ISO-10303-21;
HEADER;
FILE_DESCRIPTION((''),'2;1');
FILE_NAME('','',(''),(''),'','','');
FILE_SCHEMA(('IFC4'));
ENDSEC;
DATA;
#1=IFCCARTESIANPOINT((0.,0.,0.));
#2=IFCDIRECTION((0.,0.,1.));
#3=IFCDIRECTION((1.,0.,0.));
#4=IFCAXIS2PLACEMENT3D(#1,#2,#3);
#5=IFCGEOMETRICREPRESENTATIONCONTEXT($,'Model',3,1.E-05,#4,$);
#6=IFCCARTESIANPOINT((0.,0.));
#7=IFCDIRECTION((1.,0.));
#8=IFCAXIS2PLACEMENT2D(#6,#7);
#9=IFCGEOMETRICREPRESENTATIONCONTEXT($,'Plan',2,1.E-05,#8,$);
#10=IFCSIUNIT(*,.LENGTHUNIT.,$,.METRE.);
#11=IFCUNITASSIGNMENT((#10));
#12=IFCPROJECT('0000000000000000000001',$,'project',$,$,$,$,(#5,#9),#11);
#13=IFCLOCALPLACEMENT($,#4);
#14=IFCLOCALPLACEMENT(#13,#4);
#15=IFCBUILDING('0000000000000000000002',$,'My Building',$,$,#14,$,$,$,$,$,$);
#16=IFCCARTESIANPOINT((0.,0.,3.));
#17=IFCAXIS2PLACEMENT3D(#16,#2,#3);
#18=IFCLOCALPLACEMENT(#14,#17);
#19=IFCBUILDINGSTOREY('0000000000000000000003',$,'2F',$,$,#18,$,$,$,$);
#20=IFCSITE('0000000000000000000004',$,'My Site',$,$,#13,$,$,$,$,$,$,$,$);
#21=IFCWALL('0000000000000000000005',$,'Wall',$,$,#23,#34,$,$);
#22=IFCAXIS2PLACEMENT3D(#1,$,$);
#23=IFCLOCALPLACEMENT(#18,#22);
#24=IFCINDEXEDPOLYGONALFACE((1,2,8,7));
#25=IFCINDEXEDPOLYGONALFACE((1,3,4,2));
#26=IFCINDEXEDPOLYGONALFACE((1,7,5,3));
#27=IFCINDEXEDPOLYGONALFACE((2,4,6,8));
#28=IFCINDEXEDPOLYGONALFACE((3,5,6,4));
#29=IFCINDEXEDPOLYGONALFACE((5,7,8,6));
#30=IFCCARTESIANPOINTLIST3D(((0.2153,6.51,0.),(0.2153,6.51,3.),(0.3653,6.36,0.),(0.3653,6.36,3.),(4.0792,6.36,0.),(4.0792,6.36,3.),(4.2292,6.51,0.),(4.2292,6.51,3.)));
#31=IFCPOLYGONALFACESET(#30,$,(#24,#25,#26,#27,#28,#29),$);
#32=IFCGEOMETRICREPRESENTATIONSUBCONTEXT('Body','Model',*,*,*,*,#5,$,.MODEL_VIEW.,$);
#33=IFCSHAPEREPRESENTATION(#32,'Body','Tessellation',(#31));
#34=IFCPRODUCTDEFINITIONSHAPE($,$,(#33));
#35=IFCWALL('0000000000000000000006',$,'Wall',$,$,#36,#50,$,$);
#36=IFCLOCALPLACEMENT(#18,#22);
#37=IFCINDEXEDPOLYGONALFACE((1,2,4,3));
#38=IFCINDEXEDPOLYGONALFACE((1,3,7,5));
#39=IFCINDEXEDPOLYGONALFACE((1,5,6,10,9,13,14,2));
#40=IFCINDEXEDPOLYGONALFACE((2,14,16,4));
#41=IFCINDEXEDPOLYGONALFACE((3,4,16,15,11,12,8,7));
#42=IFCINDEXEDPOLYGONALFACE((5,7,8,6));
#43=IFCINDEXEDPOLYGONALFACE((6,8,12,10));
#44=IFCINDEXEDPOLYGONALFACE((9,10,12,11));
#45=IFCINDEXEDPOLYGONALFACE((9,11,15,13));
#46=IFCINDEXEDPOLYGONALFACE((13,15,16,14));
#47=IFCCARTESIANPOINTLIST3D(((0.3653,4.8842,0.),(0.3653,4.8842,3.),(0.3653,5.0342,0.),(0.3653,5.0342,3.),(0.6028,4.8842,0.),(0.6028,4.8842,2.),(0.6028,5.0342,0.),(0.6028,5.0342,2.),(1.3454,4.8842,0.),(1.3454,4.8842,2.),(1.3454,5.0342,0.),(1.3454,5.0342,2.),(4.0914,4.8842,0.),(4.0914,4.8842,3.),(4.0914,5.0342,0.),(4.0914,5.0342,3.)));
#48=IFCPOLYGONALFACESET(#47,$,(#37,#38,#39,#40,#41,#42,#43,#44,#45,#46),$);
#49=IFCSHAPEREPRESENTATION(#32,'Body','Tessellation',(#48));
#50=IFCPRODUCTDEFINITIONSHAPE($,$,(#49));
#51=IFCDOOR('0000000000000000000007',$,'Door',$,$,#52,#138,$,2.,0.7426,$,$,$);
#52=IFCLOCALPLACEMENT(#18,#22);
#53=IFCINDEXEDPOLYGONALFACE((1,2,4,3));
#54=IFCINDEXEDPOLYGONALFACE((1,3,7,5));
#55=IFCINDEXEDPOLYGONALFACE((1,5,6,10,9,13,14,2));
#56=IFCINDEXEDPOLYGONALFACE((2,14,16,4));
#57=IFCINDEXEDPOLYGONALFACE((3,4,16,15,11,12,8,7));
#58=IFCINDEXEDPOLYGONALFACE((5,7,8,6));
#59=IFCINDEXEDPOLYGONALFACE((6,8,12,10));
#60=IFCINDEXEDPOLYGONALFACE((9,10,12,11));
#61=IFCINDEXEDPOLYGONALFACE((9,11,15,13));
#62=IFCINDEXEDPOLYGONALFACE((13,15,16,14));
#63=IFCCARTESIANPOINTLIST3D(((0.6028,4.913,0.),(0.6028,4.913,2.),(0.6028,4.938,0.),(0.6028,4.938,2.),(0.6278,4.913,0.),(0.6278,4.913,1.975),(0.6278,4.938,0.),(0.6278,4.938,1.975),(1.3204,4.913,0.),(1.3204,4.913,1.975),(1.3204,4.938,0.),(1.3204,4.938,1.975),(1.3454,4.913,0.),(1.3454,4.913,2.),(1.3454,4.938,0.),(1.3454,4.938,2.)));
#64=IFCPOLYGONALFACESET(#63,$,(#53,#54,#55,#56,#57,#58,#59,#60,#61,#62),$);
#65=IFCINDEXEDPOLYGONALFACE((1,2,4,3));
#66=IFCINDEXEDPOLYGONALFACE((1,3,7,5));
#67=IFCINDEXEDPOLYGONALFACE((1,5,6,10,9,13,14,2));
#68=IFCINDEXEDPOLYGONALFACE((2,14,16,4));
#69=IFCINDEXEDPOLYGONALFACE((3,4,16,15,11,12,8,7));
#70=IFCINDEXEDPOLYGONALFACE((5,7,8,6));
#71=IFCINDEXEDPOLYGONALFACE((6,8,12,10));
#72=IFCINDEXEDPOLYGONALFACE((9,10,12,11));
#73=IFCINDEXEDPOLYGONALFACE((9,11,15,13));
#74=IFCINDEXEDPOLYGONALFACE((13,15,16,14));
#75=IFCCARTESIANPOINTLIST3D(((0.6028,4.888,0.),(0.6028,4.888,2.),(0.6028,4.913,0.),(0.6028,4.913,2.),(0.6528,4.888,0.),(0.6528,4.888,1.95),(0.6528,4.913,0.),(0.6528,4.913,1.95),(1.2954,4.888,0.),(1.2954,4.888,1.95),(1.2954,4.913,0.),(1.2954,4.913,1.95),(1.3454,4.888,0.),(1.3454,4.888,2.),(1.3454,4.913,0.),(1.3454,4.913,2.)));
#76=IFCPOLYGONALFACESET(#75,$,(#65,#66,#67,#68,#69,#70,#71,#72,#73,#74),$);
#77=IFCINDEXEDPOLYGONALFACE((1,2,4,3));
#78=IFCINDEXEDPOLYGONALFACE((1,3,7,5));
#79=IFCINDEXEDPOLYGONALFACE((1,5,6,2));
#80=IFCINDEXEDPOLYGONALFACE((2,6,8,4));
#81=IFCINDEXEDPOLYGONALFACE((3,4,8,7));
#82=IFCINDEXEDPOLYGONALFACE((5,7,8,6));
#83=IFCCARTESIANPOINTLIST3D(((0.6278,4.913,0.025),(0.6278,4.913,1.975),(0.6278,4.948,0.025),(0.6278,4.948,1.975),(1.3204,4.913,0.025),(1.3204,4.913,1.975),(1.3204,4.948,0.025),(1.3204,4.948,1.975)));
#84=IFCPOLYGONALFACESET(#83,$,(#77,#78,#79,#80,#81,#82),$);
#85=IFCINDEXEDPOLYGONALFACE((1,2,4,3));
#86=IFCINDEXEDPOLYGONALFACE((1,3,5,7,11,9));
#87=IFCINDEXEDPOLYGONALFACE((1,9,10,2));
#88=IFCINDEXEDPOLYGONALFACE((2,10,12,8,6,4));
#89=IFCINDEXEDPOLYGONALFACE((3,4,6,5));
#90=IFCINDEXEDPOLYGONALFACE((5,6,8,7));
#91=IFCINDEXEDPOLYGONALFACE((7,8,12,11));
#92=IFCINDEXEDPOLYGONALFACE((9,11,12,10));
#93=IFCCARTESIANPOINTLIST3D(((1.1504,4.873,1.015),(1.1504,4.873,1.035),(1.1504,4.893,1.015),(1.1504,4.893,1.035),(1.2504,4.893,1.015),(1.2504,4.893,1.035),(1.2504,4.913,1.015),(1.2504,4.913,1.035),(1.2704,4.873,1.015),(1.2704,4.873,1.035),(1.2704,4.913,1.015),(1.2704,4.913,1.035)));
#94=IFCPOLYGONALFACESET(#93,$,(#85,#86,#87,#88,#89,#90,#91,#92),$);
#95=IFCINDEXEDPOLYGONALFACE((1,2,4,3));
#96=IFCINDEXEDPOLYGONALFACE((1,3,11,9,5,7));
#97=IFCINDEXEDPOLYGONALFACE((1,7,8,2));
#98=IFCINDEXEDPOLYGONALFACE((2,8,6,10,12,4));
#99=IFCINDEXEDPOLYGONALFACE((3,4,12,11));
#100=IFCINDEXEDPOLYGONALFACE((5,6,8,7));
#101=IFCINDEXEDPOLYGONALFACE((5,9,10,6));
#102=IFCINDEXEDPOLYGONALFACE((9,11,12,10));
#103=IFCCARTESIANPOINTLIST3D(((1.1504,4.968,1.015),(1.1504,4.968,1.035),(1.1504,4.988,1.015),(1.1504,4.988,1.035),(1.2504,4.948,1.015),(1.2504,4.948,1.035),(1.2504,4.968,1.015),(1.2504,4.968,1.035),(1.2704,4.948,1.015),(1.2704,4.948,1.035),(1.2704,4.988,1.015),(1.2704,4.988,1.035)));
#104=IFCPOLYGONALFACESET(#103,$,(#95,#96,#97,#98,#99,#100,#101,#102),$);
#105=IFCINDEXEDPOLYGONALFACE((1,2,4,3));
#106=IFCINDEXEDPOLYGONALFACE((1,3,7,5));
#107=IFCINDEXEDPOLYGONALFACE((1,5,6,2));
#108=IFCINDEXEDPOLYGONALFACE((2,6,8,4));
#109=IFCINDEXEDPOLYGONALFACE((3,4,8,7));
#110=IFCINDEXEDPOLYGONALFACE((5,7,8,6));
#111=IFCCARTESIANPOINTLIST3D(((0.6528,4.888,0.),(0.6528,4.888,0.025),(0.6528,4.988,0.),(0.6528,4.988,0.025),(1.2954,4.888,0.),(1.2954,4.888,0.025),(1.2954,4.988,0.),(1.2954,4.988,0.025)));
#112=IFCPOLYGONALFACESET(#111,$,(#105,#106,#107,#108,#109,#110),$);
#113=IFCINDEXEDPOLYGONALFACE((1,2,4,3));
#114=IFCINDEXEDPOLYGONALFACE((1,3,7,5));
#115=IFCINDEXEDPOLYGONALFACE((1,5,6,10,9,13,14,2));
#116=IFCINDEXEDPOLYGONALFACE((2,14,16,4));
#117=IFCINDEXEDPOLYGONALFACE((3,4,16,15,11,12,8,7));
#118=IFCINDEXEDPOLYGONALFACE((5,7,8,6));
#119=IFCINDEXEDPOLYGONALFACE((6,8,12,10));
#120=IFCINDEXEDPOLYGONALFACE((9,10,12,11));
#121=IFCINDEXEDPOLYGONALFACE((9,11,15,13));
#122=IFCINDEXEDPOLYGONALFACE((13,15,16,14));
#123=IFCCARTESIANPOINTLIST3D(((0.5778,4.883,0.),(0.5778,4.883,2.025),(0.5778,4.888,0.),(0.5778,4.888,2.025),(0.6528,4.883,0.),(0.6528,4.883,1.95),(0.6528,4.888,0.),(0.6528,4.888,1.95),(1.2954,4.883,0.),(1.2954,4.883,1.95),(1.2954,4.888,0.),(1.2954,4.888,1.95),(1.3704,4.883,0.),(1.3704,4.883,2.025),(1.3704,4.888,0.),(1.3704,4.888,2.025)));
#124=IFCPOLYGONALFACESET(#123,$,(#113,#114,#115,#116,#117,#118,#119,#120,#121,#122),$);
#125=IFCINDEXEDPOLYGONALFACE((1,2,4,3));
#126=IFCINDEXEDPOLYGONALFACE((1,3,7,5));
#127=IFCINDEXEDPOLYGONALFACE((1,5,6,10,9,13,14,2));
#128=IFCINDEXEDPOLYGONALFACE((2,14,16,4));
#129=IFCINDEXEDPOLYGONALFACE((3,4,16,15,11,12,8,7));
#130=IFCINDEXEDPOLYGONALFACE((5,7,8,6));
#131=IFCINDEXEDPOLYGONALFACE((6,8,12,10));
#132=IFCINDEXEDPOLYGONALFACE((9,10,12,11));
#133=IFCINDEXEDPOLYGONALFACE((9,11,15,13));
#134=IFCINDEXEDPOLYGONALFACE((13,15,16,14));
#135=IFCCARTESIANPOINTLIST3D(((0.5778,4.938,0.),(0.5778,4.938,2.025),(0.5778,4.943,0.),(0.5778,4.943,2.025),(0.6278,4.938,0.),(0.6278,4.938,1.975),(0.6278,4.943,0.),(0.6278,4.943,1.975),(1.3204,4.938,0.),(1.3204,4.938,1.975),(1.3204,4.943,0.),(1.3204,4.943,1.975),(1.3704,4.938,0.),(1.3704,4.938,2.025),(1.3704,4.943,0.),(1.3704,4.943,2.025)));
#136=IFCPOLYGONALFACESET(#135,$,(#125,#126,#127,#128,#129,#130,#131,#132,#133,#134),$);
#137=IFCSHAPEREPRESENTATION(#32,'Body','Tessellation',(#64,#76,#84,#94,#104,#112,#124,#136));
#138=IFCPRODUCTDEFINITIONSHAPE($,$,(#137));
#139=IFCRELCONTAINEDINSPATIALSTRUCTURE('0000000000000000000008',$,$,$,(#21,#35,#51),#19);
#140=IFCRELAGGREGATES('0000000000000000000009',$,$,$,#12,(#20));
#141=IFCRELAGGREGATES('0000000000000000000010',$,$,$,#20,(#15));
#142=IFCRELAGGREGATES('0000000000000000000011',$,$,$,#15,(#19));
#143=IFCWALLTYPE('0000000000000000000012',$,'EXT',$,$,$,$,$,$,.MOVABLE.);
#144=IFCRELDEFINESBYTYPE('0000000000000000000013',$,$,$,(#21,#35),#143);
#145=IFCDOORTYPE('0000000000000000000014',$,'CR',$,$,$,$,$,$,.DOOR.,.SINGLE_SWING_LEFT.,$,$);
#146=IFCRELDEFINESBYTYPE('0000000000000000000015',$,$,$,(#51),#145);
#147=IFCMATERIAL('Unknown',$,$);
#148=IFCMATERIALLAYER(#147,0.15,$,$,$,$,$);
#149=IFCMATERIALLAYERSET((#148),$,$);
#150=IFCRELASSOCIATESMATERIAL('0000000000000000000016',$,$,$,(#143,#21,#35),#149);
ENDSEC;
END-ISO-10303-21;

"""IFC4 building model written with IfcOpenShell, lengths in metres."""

from ifc_helpers import new_model, entity, si_unit, frame, origin_with_axes, origin_2d_with_axis, place, context, subcontext, project, spatial, line, indexed_curve, outline, extrude, shape, source, transform, mapped, material, layer, layer_set, layer_usage, type_object, type_shapes, element, fill, save


model = new_model("IFC4")

# Units and contexts
model_context = context("Model", 3, precision=1e-05, world=origin_with_axes())
plan_context = context("Plan", 2, precision=1e-05, world=origin_2d_with_axis())
body_context_1 = subcontext(model_context, "Body", "Model", "MODEL_VIEW")
body_context_2 = subcontext(plan_context, "Body", "Plan", "PLAN_VIEW")
ifc_project = project(units=[si_unit("LENGTHUNIT", "METRE")], contexts=[model_context, plan_context])

# Site, building, storey
site_placement = place(None, origin_with_axes())
site = spatial("IfcSite", under=ifc_project, at=site_placement, Name="My Site")
building_placement = place(site_placement, origin_with_axes())
building = spatial("IfcBuilding", under=site, at=building_placement, Name="My Building")
storey_placement = place(building_placement, frame((0.0, 0.0, 3.0), z_axis=(0.0, 0.0, 1.0), x_axis=(1.0, 0.0, 0.0)))
storey = spatial("IfcBuildingStorey", under=building, at=storey_placement, Name="2F")

# Shared definitions
ifc_material = material(Name="Unknown")

# Shared definitions
ifc_layer_1 = layer(ifc_material, 0.15)
ifc_layer_set_1 = layer_set([ifc_layer_1])
wall_type_1 = type_object("IfcWallType", Name="EXT", PredefinedType="MOVABLE", material=ifc_layer_set_1)

# Wall
ifc_layer_usage_1 = layer_usage(ifc_layer_set_1, "AXIS2", "POSITIVE", -0.15)
wall_1_placement = place(storey_placement, frame((0.2153, 6.51, 0.0), z_axis=(0.0, 0.0, 1.0), x_axis=(1.0, 0.0, 0.0)))
element("IfcWall", 1, at=wall_1_placement, inside=storey, type_object=wall_type_1, material=ifc_layer_usage_1, Name="Wall", context=body_context_1, shape_type="SweptSolid", body=[
    extrude(outline(indexed_curve([(0.15, -0.15), (0.0, 0.0), (4.0139, 0.0), (3.8639, -0.15)], segments=[line(1, 2, 3, 4, 1)])), origin_with_axes(), (0.0, 0.0, 1.0), 3.0),
])

# Wall, opening, door
ifc_layer_usage_2 = layer_usage(ifc_layer_set_1, "AXIS2", "POSITIVE", -0.15)
wall_2_placement = place(storey_placement, frame((4.0914, 4.8842, 0.0), z_axis=(0.0, 0.0, 1.0), x_axis=(-1.0, 0.0, 0.0)))
wall_2 = element("IfcWall", 2, at=wall_2_placement, inside=storey, type_object=wall_type_1, material=ifc_layer_usage_2, Name="Wall", context=body_context_1, shape_type="SweptSolid", body=[
    extrude(outline(indexed_curve([(0.0, -0.15), (0.0, 0.0), (3.7261, 0.0), (3.7261, -0.15)], segments=[line(1, 2, 3, 4, 1)])), origin_with_axes(), (0.0, 0.0, 1.0), 3.0),
])
placement_1 = place(storey_placement, frame((0.6028, 4.888, 0.0), z_axis=(0.0, 0.0, 1.0), x_axis=(1.0, 0.0, 0.0)))
opening_1 = element("IfcOpeningElement", 3, at=placement_1, cuts=wall_2, PredefinedType="OPENING", context=body_context_1, shape_type="SweptSolid", body=[
    extrude(outline(indexed_curve([(0.0, 0.0), (0.7426, 0.0), (0.7426, 2.0), (0.0, 2.0)], segments=[line(1, 2, 3, 4, 1)])), frame((0.0, -0.6, 0.0), z_axis=(0.0, -1.0, 0.0), x_axis=(1.0, 0.0, 0.0)), (0.0, 0.0, -1.0), 1.2),
])
door_type_1 = type_object("IfcDoorType", Name="CR", OperationType="SINGLE_SWING_LEFT", PredefinedType="DOOR")
shared_shape_1 = source(origin_with_axes(), body_context_1, "Body", "SweptSolid", [
    extrude(outline(indexed_curve([(0.0, 0.0), (0.0, 2.0), (0.7426, 2.0), (0.7426, 0.0), (0.7176, 0.0), (0.7176, 1.975), (0.025, 1.975), (0.025, 0.0)], segments=[line(1, 2, 3, 4, 5, 6, 7, 8, 1)])), frame((0.0, 0.025, 0.0), z_axis=(0.0, -1.0, 0.0), x_axis=(1.0, 0.0, 0.0)), (0.0, 0.0, -1.0), 0.025),
    extrude(outline(indexed_curve([(0.0, 0.0), (0.0, 2.0), (0.7426, 2.0), (0.7426, 0.0), (0.6926, 0.0), (0.6926, 1.95), (0.05, 1.95), (0.05, 0.0)], segments=[line(1, 2, 3, 4, 5, 6, 7, 8, 1)])), frame((0.0, 0.0, 0.0), z_axis=(0.0, -1.0, 0.0), x_axis=(1.0, 0.0, 0.0)), (0.0, 0.0, -1.0), 0.025),
    extrude(outline(indexed_curve([(0.0, 0.0), (0.6926, 0.0), (0.6926, 0.035), (0.0, 0.035)], segments=[line(1, 2, 3, 4, 1)])), frame((0.025, 0.025, 0.025), z_axis=(0.0, 0.0, 1.0), x_axis=(1.0, 0.0, 0.0)), (0.0, 0.0, 1.0), 1.95),
    extrude(outline(indexed_curve([(0.0, 0.0), (0.0, -0.04), (-0.12, -0.04), (-0.12, -0.02), (-0.02, -0.02), (-0.02, 0.0)], segments=[line(1, 2, 3, 4, 5, 6, 1)])), frame((0.6676, 0.025, 1.015), z_axis=(0.0, 0.0, 1.0), x_axis=(1.0, 0.0, 0.0)), (0.0, 0.0, 1.0), 0.02),
    extrude(outline(indexed_curve([(0.0, 0.0), (0.0, 0.04), (-0.12, 0.04), (-0.12, 0.02), (-0.02, 0.02), (-0.02, 0.0)], segments=[line(1, 2, 3, 4, 5, 6, 1)])), frame((0.6676, 0.06, 1.015), z_axis=(0.0, 0.0, 1.0), x_axis=(1.0, 0.0, 0.0)), (0.0, 0.0, 1.0), 0.02),
    extrude(outline(indexed_curve([(0.0, 0.0), (0.6426, 0.0), (0.6426, 0.1), (0.0, 0.1)], segments=[line(1, 2, 3, 4, 1)])), frame((0.05, 0.0, 0.0), z_axis=(0.0, 0.0, 1.0), x_axis=(1.0, 0.0, 0.0)), (0.0, 0.0, 1.0), 0.025),
    extrude(outline(indexed_curve([(0.0, 0.0), (0.0, 2.025), (0.7926, 2.025), (0.7926, 0.0), (0.7176, 0.0), (0.7176, 1.95), (0.075, 1.95), (0.075, 0.0)], segments=[line(1, 2, 3, 4, 5, 6, 7, 8, 1)])), frame((-0.025, -0.005, 0.0), z_axis=(0.0, -1.0, 0.0), x_axis=(1.0, 0.0, 0.0)), (0.0, 0.0, -1.0), 0.005),
    extrude(outline(indexed_curve([(0.0, 0.0), (0.0, 2.025), (0.7926, 2.025), (0.7926, 0.0), (0.7426, 0.0), (0.7426, 1.975), (0.05, 1.975), (0.05, 0.0)], segments=[line(1, 2, 3, 4, 5, 6, 7, 8, 1)])), frame((-0.025, 0.05, 0.0), z_axis=(0.0, -1.0, 0.0), x_axis=(1.0, 0.0, 0.0)), (0.0, 0.0, -1.0), 0.005),
])
shared_shape_2 = source(origin_with_axes(), body_context_2, "Body", "Curve2D", [
    entity("IfcIndexedPolyCurve", entity("IfcCartesianPointList2D", [[0.0, 0.0], [0.0, 0.05], [0.025, 0.05], [0.025, 0.025], [0.05, 0.025], [0.05, 0.0]]), [entity("IfcLineIndex", [1, 2, 3, 4, 5, 6, 1])]),
    entity("IfcIndexedPolyCurve", entity("IfcCartesianPointList2D", [[0.7426, 0.0], [0.7426, 0.05], [0.7176, 0.05], [0.7176, 0.025], [0.6926, 0.025], [0.6926, 0.0]]), [entity("IfcLineIndex", [1, 2, 3, 4, 5, 6, 1])]),
    entity("IfcTrimmedCurve", entity("IfcEllipse", entity("IfcAxis2Placement2D", entity("IfcCartesianPoint", [0.06, 0.05]), entity("IfcDirection", [1.0, 0.0])), 0.6576, 0.6926), [entity("IfcCartesianPoint", [0.7176, 0.05])], [entity("IfcCartesianPoint", [0.06, 0.7426])], True, "CARTESIAN"),
    entity("IfcIndexedPolyCurve", entity("IfcCartesianPointList2D", [[0.025, 0.05], [0.06, 0.05], [0.06, 0.7426], [0.025, 0.7426]]), [entity("IfcLineIndex", [1, 2, 3, 4, 1])]),
])
type_shapes(door_type_1, [shared_shape_1, shared_shape_2])
door_1 = element("IfcDoor", 4, at=placement_1, inside=storey, type_object=door_type_1, Name="Door", OverallHeight=2.0, OverallWidth=0.7426, shapes=[
    shape(body_context_1, "Body", "MappedRepresentation", [mapped(shared_shape_1, transform((0.0, 0.0, 0.0), x_axis=(1.0, 0.0, 0.0), y_axis=(0.0, 1.0, 0.0), z_axis=(0.0, 0.0, 1.0), scale=1.0))]),
    shape(body_context_2, "Body", "MappedRepresentation", [mapped(shared_shape_2, transform((0.0, 0.0, 0.0), x_axis=(1.0, 0.0, 0.0), y_axis=(0.0, 1.0, 0.0), z_axis=(0.0, 0.0, 1.0), scale=1.0))]),
])
fill(opening_1, door_1)

save(model, "model.ifc")
